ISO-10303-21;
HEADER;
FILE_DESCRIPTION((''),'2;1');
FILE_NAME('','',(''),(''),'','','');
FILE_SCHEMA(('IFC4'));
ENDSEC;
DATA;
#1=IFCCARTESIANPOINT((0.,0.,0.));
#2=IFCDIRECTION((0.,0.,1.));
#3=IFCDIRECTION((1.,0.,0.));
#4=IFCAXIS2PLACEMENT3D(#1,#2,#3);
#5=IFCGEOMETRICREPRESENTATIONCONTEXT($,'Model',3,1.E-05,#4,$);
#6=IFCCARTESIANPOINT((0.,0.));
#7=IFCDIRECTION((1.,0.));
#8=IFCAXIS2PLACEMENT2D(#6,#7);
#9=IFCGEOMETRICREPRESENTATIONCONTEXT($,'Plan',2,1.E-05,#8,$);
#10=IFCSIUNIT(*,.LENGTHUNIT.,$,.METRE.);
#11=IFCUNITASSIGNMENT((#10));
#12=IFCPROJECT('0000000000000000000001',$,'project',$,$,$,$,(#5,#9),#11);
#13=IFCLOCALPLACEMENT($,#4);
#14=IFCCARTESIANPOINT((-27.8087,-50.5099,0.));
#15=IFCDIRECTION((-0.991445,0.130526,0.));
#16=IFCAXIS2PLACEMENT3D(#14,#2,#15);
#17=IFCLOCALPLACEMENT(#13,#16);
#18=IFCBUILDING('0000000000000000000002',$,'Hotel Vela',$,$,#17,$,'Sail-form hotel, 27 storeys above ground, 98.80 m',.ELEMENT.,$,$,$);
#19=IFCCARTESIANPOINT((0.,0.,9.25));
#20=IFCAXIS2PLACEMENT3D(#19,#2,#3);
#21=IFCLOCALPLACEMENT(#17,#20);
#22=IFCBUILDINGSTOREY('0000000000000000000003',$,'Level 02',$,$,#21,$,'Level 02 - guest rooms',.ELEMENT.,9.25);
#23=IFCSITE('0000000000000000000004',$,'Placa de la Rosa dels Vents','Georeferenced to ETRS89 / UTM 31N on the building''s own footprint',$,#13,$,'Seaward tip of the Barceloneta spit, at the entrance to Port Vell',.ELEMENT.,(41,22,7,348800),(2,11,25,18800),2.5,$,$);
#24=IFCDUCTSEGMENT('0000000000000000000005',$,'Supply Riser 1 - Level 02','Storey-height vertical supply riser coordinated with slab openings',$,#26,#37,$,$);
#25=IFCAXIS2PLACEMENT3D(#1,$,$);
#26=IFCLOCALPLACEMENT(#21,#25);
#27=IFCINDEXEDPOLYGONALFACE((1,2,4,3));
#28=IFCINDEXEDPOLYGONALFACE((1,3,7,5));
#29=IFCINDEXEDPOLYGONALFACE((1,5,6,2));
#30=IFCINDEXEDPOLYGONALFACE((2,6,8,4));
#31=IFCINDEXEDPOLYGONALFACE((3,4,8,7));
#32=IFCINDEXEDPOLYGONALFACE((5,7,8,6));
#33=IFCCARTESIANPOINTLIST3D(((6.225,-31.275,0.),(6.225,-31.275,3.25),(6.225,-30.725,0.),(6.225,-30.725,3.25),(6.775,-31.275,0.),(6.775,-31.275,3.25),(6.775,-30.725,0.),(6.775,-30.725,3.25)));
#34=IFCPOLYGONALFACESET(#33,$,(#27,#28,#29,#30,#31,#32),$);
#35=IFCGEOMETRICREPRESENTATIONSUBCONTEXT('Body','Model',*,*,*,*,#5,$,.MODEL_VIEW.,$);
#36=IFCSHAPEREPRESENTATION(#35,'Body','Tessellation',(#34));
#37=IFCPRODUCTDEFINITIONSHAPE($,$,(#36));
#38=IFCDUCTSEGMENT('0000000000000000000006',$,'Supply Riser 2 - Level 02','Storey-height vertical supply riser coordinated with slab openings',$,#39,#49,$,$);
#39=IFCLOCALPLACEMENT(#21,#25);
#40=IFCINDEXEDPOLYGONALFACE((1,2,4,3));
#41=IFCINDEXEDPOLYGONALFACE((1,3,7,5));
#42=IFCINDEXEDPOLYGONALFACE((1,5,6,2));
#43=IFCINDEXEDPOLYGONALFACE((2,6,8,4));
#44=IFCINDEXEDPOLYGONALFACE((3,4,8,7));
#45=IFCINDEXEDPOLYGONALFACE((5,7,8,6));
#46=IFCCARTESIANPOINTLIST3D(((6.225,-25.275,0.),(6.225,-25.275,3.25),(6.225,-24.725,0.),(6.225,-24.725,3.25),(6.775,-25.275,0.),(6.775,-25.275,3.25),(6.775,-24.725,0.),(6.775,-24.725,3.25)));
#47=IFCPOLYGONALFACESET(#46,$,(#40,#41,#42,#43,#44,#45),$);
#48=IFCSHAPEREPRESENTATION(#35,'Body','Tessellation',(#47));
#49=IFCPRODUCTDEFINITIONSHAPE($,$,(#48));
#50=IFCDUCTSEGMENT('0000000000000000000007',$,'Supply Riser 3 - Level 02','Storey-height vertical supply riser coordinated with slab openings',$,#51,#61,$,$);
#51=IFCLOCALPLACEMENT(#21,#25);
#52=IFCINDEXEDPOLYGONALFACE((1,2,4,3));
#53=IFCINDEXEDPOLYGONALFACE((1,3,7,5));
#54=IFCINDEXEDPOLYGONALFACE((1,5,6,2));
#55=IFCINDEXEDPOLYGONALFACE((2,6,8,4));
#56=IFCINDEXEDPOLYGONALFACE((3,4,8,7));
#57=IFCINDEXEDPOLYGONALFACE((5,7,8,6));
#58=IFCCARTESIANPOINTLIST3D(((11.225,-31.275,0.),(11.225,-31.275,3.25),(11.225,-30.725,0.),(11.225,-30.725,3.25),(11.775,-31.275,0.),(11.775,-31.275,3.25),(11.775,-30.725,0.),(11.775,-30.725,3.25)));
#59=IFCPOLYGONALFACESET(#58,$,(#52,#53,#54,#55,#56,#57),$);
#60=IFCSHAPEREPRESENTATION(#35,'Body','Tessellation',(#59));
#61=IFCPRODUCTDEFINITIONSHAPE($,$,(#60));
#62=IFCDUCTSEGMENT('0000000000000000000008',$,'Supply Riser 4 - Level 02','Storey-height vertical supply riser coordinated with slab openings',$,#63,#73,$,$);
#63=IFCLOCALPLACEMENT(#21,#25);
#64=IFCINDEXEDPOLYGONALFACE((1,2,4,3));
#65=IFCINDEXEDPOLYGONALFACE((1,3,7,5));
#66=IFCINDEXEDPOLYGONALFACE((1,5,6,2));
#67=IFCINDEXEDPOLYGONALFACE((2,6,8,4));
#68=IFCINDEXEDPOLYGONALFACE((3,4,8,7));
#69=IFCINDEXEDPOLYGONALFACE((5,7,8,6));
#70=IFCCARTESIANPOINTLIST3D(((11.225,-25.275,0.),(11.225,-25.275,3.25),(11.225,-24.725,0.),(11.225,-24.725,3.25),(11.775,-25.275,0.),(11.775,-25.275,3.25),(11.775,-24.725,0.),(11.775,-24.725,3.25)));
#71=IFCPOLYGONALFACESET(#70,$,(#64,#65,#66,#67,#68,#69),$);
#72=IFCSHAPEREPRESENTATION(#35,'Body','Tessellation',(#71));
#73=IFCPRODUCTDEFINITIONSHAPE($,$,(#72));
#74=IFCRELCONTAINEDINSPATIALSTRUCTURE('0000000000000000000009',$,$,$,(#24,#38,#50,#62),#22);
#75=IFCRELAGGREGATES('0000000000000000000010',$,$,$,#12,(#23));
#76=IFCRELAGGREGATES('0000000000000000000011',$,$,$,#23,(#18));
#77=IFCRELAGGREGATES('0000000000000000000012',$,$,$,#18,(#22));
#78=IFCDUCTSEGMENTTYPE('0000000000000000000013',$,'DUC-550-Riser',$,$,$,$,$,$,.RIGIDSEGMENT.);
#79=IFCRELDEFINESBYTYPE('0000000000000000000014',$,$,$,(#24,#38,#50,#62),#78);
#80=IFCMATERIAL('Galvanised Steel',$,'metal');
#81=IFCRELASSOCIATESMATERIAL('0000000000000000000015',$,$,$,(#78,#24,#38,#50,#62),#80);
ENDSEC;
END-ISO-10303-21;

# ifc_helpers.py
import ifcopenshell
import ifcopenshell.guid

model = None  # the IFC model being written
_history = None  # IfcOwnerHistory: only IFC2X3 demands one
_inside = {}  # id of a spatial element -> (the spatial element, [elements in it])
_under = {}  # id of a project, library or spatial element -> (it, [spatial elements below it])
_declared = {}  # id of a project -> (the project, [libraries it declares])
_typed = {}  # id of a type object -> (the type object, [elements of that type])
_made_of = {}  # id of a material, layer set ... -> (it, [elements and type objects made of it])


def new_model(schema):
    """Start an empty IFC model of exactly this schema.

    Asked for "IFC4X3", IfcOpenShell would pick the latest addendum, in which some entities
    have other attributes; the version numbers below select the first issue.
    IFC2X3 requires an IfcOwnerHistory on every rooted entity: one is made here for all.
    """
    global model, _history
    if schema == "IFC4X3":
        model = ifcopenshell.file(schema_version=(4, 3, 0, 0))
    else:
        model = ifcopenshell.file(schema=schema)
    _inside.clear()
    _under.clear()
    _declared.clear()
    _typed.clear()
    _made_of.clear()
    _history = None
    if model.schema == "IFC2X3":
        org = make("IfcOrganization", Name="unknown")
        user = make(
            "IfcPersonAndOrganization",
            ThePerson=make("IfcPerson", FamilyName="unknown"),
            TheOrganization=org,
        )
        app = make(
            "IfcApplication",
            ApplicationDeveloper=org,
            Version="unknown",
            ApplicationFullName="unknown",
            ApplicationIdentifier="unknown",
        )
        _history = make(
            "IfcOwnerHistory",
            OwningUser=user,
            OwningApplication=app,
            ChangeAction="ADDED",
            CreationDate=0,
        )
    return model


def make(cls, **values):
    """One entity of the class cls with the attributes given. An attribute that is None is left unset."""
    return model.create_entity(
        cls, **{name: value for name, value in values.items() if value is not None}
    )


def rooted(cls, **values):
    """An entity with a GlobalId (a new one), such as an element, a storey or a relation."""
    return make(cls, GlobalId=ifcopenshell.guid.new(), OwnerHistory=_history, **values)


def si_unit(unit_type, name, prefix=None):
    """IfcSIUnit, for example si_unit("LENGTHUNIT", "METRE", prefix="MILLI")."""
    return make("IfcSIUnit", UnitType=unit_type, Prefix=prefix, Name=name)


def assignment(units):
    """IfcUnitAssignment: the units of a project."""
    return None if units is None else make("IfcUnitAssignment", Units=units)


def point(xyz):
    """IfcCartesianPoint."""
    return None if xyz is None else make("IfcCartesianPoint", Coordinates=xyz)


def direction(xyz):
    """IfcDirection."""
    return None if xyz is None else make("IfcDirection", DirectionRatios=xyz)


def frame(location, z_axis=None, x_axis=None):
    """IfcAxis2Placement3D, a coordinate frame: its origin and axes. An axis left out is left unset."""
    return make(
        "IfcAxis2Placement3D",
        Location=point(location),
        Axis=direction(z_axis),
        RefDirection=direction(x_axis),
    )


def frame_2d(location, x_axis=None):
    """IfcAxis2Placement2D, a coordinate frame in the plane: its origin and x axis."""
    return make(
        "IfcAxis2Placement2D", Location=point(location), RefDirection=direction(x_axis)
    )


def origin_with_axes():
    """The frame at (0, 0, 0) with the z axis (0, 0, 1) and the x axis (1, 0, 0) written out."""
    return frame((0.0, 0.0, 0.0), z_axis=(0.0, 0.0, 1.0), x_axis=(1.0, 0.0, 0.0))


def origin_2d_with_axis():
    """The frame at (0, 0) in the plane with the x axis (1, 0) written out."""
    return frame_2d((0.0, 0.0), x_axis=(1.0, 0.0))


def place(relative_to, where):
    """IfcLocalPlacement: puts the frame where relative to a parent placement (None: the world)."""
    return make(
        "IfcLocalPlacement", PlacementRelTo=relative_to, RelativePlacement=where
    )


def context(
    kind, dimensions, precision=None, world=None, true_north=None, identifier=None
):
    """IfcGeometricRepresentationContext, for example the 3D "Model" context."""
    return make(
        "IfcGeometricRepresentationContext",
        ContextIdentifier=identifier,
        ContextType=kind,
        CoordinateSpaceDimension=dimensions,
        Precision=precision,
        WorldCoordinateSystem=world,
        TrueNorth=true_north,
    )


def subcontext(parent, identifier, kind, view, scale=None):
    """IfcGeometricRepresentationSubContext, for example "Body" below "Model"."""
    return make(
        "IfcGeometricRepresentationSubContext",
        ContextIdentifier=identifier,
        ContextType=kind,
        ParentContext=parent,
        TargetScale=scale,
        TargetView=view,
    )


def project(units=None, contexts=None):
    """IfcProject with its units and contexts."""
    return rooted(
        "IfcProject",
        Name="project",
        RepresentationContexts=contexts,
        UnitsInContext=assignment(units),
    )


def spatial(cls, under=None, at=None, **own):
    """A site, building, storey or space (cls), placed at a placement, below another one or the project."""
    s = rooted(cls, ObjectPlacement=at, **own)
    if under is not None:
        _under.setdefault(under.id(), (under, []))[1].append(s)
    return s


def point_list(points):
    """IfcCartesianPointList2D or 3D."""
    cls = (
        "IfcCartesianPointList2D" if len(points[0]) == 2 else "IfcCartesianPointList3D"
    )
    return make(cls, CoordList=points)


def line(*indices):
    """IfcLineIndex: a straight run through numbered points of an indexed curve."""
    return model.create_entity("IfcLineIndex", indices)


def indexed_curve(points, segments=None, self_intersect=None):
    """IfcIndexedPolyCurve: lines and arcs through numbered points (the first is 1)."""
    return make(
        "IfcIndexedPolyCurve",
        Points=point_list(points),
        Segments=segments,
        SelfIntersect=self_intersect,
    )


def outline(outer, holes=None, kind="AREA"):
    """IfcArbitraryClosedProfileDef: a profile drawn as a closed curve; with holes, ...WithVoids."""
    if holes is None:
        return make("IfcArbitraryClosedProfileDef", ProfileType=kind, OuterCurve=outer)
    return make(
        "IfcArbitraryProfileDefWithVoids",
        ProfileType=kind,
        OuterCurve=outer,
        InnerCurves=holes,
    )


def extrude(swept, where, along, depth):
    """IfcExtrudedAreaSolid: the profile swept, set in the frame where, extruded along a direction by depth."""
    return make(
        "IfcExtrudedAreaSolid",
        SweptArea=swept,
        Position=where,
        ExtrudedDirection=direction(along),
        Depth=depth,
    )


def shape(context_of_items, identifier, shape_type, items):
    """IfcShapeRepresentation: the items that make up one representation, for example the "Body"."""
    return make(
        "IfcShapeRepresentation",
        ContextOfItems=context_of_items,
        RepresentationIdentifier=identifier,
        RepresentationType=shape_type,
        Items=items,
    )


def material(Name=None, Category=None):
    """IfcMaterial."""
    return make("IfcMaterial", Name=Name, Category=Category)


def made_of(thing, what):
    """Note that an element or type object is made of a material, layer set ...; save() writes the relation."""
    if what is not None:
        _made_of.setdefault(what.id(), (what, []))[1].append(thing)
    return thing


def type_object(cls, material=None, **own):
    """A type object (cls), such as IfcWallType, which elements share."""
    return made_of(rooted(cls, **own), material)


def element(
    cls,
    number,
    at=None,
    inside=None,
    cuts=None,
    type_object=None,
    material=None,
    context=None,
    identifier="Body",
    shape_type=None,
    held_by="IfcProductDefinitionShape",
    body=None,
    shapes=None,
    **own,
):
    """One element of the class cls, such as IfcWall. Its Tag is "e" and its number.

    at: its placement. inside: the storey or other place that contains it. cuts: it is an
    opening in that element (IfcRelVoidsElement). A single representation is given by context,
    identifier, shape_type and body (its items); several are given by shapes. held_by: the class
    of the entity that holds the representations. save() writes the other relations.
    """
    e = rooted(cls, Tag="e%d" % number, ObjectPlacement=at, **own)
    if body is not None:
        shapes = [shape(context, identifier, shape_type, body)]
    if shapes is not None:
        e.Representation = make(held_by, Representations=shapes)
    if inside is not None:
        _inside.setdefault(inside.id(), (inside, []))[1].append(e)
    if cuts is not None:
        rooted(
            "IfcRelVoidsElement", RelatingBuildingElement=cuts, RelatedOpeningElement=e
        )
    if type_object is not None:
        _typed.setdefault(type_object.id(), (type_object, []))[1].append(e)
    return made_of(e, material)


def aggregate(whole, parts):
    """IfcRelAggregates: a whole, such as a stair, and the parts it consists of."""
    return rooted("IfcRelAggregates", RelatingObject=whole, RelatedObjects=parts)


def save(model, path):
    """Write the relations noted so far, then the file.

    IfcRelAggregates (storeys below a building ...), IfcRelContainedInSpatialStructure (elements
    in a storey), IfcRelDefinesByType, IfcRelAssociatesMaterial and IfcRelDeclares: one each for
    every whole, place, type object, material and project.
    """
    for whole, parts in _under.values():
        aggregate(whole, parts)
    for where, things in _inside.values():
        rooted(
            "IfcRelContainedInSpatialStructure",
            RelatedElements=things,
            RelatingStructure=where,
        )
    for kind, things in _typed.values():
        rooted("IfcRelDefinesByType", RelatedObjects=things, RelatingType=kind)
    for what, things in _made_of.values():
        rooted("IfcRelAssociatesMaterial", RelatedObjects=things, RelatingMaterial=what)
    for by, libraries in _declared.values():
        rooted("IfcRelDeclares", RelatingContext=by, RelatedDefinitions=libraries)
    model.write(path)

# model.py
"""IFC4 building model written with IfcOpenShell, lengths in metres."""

from ifc_helpers import new_model, si_unit, frame, origin_with_axes, origin_2d_with_axis, place, context, subcontext, project, spatial, line, indexed_curve, outline, extrude, material, type_object, element, save


model = new_model("IFC4")

# Units and contexts
model_context = context("Model", 3, precision=1e-05, world=origin_with_axes())
plan_context = context("Plan", 2, precision=1e-05, world=origin_2d_with_axis())
body_context = subcontext(model_context, "Body", "Model", "MODEL_VIEW")
ifc_project = project(units=[si_unit("LENGTHUNIT", "METRE")], contexts=[model_context, plan_context])

# Site, building, storey
site_placement = place(None, origin_with_axes())
site = spatial("IfcSite", under=ifc_project, at=site_placement, Name="Placa de la Rosa dels Vents", Description="Georeferenced to ETRS89 / UTM 31N on the building's own footprint", LongName="Seaward tip of the Barceloneta spit, at the entrance to Port Vell", CompositionType="ELEMENT", RefLatitude=(41, 22, 7, 348800), RefLongitude=(2, 11, 25, 18800), RefElevation=2.5)
building_placement = place(site_placement, frame((-27.8087, -50.5099, 0.0), z_axis=(0.0, 0.0, 1.0), x_axis=(-0.991445, 0.130526, 0.0)))
building = spatial("IfcBuilding", under=site, at=building_placement, Name="Hotel Vela", LongName="Sail-form hotel, 27 storeys above ground, 98.80 m", CompositionType="ELEMENT")
storey_placement = place(building_placement, frame((0.0, 0.0, 9.25), z_axis=(0.0, 0.0, 1.0), x_axis=(1.0, 0.0, 0.0)))
storey = spatial("IfcBuildingStorey", under=building, at=storey_placement, Name="Level 02", LongName="Level 02 - guest rooms", CompositionType="ELEMENT", Elevation=9.25)

# Duct segments
ifc_material = material(Name="Galvanised Steel", Category="metal")
duct_segment_type = type_object("IfcDuctSegmentType", Name="DUC-550-Riser", PredefinedType="RIGIDSEGMENT", material=ifc_material)
for number, where, z_axis, x_axis, name in (
    (1, (6.225, -31.275, 0.0), (0.0, 0.0, 1.0), (1.0, 0.0, 0.0), "Supply Riser 1 - Level 02"),
    (2, (6.225, -25.275, 0.0), (0.0, 0.0, 1.0), (1.0, 0.0, 0.0), "Supply Riser 2 - Level 02"),
    (3, (11.225, -31.275, 0.0), (0.0, 0.0, 1.0), (1.0, 0.0, 0.0), "Supply Riser 3 - Level 02"),
    (4, (11.225, -25.275, 0.0), (0.0, 0.0, 1.0), (1.0, 0.0, 0.0), "Supply Riser 4 - Level 02"),
):
    element("IfcDuctSegment", number, at=place(storey_placement, frame(where, z_axis=z_axis, x_axis=x_axis)), inside=storey, type_object=duct_segment_type, material=ifc_material, Name=name, Description="Storey-height vertical supply riser coordinated with slab openings", context=body_context, shape_type="SweptSolid", body=[
        extrude(outline(indexed_curve([(0.0, 0.0), (0.55, 0.0), (0.55, 0.55), (0.0, 0.55)], segments=[line(1, 2, 3, 4, 1)])), origin_with_axes(), (0.0, 0.0, 1.0), 3.25),
    ])

save(model, "model.ifc")
